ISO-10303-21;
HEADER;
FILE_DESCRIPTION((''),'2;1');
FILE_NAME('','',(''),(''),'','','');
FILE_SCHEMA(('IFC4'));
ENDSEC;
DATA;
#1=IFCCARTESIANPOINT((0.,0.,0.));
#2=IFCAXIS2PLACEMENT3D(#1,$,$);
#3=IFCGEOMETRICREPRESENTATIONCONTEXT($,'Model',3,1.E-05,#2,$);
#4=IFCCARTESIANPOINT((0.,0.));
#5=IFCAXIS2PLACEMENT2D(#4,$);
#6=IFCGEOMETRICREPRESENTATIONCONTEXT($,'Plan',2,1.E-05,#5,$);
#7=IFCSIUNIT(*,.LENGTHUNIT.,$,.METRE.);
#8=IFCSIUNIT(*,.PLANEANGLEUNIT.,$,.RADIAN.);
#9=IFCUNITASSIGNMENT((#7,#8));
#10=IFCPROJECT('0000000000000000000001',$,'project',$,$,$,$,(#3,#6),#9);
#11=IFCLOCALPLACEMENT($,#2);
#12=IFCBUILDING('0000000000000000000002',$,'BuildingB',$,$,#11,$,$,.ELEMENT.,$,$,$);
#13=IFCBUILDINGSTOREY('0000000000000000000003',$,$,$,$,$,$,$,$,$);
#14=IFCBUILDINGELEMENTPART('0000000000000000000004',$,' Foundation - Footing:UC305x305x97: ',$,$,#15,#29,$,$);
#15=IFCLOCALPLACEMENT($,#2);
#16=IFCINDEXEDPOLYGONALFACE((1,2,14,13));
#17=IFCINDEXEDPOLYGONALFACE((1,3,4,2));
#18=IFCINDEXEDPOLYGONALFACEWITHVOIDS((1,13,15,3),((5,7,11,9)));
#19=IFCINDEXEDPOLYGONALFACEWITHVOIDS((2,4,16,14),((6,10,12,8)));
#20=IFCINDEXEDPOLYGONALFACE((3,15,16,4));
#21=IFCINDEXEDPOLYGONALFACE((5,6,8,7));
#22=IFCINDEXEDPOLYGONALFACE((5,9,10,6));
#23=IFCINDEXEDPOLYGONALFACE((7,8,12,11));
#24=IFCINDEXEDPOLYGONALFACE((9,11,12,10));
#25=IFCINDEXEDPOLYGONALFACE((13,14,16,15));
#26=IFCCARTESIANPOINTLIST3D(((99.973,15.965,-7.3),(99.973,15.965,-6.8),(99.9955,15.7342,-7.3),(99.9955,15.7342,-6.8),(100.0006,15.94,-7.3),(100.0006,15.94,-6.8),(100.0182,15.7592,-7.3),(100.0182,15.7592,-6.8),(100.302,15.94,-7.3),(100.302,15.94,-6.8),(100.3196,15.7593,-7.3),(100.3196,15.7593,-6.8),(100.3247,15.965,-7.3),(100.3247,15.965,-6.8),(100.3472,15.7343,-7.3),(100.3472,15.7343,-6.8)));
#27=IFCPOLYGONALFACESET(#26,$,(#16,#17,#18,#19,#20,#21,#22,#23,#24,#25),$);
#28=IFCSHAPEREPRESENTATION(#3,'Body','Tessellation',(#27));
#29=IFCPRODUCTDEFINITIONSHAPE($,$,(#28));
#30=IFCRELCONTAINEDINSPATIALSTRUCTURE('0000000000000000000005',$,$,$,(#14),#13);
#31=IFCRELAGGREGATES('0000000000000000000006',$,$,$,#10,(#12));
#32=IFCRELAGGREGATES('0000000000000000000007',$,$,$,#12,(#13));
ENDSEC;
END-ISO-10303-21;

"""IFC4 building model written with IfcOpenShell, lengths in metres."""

from ifc_helpers import new_model, si_unit, origin, origin_2d, place, context, project, spatial, polyline, outline, extrude, element, save


model = new_model("IFC4")

# Units and contexts
model_context = context("Model", 3, precision=1e-05, world=origin())
plan_context = context("Plan", 2, precision=1e-05, world=origin_2d())
ifc_project = project(units=[si_unit("LENGTHUNIT", "METRE"), si_unit("PLANEANGLEUNIT", "RADIAN")], contexts=[model_context, plan_context])

# Building, storey
building_placement = place(None, origin())
building = spatial("IfcBuilding", under=ifc_project, at=building_placement, Name="BuildingB", CompositionType="ELEMENT")
storey = spatial("IfcBuildingStorey", under=building)

# Building element part, opening
building_element_part_1 = element("IfcBuildingElementPart", 1, inside=storey, Name=" Foundation - Footing:UC305x305x97: ", context=model_context, shape_type="SweptSolid", body=[
    extrude(outline(polyline([(100.3472, 15.7343, -7.3), (100.3247, 15.965, -7.3), (99.973, 15.965, -7.3), (99.9955, 15.7342, -7.3), (100.3472, 15.7343, -7.3)])), None, (0.0, 0.0, 1.0), 0.5),
])
element("IfcOpeningElement", 2, inside=storey, cuts=building_element_part_1, context=model_context, shape_type="SweptSolid", body=[
    extrude(outline(polyline([(100.3196, 15.7593, -7.3), (100.302, 15.94, -7.3), (100.0006, 15.94, -7.3), (100.0182, 15.7592, -7.3), (100.3196, 15.7593, -7.3)])), None, (0.0, 0.0, 1.0), 0.5),
])

save(model, "model.ifc")
